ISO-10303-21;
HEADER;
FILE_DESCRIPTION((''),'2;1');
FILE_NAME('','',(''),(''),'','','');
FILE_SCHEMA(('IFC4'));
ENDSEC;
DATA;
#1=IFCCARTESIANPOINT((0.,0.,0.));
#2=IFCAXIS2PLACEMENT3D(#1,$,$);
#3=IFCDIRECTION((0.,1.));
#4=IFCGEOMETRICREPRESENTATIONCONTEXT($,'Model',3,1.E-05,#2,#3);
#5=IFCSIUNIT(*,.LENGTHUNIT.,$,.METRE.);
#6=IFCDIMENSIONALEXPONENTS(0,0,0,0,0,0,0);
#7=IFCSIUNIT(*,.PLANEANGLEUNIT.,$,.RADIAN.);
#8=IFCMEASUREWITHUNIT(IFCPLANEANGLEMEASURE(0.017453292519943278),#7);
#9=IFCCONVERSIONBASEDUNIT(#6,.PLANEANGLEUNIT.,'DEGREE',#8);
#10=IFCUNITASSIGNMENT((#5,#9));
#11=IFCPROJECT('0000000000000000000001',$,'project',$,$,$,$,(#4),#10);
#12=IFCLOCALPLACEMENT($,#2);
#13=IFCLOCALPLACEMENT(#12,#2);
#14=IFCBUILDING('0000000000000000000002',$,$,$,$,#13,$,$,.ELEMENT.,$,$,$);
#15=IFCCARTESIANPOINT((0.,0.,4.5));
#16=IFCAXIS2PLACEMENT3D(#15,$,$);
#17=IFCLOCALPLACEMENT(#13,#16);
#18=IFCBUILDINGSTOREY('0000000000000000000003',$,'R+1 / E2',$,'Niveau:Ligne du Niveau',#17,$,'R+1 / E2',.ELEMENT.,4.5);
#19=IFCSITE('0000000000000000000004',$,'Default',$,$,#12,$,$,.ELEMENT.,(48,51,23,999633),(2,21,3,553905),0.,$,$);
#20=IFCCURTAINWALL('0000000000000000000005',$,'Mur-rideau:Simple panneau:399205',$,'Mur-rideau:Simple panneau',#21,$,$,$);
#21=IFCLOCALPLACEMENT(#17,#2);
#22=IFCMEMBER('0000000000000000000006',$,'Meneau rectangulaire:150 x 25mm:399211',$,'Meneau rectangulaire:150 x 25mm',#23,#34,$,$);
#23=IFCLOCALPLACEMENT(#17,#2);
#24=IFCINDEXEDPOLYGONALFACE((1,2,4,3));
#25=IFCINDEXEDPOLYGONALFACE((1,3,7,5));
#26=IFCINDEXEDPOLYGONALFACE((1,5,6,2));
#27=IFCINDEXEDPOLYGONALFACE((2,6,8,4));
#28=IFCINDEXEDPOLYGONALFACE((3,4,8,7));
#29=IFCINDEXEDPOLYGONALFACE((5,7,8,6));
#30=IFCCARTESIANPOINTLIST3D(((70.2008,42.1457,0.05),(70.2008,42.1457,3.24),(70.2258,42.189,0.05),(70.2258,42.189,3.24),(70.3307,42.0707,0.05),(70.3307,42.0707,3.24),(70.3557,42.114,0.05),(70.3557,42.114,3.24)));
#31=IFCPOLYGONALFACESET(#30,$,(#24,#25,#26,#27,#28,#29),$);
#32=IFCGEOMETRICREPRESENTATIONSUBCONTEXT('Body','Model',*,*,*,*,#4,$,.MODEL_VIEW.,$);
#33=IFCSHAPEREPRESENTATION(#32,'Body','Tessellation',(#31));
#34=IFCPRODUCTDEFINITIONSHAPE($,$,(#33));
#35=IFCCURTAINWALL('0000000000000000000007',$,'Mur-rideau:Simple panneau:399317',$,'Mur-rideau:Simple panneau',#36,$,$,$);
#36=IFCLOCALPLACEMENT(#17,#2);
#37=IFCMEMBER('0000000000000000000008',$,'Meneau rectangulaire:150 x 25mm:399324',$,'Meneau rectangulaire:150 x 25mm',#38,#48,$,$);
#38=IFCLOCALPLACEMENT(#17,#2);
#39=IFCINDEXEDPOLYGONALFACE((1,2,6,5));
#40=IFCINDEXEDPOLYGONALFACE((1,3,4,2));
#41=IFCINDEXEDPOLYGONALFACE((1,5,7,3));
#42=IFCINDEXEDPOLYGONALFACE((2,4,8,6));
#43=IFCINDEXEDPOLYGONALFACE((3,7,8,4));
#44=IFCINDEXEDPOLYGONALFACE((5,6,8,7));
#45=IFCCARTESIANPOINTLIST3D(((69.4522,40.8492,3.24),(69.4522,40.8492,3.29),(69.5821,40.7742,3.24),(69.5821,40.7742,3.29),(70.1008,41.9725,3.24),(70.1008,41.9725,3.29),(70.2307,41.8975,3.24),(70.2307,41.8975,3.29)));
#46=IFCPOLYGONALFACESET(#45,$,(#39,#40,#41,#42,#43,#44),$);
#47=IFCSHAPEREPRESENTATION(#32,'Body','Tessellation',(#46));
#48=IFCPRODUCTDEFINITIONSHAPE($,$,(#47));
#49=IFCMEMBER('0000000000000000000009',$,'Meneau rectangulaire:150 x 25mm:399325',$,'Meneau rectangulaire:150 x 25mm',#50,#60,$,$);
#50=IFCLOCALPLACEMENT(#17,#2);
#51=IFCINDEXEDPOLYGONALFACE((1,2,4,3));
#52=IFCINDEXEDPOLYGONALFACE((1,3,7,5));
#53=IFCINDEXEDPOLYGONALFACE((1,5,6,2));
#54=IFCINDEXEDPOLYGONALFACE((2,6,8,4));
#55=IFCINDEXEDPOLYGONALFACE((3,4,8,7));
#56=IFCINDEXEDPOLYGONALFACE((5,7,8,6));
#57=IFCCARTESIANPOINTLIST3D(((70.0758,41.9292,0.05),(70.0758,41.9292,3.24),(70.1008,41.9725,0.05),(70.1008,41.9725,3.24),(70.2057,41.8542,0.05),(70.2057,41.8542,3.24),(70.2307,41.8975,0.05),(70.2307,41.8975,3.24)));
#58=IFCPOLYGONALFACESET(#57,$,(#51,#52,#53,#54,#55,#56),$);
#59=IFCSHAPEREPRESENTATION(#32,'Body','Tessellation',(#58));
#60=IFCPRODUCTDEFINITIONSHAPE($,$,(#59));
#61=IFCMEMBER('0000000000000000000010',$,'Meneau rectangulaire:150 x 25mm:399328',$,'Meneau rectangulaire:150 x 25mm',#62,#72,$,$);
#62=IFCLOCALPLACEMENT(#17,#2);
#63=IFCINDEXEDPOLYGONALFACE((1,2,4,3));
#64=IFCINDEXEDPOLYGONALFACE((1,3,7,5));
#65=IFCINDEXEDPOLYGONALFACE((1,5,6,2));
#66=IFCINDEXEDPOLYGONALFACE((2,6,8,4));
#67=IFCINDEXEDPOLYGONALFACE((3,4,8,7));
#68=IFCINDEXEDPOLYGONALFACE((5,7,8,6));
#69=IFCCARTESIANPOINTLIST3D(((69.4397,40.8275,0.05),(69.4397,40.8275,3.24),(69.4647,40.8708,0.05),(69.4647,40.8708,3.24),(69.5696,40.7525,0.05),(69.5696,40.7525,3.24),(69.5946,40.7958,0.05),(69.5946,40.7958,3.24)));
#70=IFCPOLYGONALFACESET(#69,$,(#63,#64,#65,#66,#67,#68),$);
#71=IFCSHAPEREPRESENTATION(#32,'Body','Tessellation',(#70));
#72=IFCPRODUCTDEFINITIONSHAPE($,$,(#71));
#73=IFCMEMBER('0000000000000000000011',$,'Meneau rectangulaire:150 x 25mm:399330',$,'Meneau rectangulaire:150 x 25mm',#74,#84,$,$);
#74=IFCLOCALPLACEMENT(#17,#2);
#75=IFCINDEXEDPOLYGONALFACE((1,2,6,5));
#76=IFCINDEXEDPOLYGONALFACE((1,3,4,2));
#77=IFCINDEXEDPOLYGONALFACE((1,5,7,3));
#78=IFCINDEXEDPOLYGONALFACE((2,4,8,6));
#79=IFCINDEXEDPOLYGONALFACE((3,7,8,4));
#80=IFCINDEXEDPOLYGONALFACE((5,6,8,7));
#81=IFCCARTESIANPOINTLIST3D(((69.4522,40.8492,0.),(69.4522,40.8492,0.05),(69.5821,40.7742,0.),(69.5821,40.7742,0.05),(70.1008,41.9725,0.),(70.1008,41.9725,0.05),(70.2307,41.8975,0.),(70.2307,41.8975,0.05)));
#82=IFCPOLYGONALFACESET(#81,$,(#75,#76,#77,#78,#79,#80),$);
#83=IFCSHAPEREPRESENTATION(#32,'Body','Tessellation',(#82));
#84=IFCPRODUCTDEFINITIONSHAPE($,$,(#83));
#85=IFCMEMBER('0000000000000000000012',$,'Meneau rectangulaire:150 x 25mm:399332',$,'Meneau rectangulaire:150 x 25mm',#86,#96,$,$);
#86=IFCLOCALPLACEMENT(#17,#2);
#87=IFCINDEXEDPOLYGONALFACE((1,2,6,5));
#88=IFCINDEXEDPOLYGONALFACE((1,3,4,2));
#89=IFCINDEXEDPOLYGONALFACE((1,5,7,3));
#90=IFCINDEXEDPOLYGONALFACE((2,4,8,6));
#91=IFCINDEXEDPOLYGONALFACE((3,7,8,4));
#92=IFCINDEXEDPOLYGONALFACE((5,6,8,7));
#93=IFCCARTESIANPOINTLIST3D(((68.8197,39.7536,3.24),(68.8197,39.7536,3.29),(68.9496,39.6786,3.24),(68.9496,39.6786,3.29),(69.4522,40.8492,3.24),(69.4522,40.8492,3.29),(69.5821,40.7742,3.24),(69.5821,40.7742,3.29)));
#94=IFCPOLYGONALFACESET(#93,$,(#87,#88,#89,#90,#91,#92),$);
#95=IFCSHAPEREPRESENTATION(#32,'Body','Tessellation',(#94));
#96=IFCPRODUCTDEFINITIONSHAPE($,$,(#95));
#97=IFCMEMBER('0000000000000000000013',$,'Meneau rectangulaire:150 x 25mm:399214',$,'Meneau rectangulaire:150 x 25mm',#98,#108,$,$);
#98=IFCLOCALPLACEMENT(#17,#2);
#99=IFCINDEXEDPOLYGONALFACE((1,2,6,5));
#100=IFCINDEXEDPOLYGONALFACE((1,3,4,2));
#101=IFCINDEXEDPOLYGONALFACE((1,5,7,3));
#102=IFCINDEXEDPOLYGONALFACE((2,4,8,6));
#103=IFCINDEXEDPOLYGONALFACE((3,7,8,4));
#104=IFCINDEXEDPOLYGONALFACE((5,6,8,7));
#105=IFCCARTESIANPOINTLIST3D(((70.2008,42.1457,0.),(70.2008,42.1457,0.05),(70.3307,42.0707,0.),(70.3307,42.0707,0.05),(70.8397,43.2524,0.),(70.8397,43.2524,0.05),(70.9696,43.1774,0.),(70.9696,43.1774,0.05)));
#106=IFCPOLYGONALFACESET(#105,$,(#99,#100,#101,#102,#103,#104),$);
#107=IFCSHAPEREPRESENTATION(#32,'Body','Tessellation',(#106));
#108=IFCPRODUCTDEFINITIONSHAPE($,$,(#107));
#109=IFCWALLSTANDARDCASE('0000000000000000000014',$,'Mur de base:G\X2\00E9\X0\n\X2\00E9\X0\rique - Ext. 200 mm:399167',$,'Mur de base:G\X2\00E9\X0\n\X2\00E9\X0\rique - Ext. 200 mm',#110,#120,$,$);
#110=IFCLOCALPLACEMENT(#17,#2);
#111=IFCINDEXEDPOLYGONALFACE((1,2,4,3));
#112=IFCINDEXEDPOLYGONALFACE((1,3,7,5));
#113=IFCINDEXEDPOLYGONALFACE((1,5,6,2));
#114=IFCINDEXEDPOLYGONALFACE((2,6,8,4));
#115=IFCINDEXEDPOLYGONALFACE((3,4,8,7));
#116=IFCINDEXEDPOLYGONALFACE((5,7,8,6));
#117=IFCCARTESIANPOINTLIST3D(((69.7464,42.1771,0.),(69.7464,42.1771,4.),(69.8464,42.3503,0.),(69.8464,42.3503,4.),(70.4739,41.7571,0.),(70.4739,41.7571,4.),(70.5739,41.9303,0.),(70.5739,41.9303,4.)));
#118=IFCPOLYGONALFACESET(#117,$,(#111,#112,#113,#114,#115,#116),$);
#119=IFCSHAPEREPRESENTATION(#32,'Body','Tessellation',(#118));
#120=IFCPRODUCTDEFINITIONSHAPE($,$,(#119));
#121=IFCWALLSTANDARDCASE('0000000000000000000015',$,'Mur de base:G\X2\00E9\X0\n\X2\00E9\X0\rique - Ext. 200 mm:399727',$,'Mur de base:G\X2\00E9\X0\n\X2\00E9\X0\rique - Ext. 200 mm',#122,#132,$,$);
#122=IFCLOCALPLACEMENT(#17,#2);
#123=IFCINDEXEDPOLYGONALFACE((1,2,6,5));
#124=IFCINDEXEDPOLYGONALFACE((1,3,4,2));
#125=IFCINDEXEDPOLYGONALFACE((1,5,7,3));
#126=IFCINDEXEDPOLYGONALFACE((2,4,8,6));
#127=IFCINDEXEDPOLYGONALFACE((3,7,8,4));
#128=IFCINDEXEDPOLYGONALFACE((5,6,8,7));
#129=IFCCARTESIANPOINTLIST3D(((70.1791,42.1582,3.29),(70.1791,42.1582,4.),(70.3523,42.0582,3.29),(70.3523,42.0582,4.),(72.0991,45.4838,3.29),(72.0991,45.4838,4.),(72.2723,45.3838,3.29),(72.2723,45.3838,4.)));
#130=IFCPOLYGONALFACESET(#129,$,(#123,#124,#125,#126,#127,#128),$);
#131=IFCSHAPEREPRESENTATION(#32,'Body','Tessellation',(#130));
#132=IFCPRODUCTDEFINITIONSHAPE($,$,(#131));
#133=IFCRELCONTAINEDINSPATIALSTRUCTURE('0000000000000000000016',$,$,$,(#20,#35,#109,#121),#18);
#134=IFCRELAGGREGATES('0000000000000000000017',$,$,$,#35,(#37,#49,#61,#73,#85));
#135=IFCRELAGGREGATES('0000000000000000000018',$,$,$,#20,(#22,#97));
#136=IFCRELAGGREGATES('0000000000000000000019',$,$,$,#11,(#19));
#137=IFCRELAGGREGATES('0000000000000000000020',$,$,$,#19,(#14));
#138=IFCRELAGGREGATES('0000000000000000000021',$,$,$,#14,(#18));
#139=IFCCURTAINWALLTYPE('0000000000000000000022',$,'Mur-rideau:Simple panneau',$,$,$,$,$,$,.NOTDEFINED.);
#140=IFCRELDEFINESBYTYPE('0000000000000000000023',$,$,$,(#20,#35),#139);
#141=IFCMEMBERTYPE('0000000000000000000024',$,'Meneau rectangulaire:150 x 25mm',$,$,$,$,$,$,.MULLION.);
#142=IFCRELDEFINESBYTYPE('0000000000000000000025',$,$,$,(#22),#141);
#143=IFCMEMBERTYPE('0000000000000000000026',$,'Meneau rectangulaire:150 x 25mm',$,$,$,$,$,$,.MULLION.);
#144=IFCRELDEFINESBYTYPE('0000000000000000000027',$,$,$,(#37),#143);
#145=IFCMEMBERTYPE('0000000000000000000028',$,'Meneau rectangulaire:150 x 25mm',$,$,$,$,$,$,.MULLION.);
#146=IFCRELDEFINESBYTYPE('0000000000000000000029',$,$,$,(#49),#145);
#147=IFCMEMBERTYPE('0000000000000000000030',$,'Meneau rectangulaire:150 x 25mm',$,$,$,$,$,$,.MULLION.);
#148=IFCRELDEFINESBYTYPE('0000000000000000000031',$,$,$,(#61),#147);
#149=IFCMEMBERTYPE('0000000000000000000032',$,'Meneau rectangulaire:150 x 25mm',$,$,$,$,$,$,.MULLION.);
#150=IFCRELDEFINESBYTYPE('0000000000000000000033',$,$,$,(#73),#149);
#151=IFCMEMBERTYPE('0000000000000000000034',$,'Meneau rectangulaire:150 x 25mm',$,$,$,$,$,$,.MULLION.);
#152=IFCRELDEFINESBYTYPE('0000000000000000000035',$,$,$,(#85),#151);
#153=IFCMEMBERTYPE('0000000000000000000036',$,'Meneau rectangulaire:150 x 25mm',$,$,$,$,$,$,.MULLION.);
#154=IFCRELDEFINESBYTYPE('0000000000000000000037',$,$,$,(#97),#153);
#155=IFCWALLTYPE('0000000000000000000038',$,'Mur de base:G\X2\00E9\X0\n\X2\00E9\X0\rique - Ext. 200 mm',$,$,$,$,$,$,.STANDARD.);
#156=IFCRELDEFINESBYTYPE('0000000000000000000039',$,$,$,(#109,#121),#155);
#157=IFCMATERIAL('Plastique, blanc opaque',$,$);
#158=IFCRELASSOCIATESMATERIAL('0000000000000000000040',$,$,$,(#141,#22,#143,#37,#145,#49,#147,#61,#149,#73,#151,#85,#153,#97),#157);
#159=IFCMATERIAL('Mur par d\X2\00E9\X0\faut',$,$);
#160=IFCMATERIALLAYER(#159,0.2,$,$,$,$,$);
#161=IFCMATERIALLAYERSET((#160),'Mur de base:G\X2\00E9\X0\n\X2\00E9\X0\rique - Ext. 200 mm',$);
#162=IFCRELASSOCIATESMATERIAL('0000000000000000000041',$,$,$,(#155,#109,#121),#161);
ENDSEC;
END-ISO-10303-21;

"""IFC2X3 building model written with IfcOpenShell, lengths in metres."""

from ifc_helpers import new_model, entity, si_unit, converted_unit, direction, frame, frame_2d, origin, origin_2d_with_axis, place, context, subcontext, project, spatial, rectangle, extrude, source, transform, mapped, material, layer, layer_set, layer_usage, type_object, type_shapes, element, aggregate, save


model = new_model("IFC2X3")

# Units and contexts
model_context = context("Model", 3, precision=1e-05, world=origin(), true_north=direction((0.0, 1.0)))
body_context = subcontext(model_context, "Body", "Model", "MODEL_VIEW")
ifc_project = project(units=[si_unit("LENGTHUNIT", "METRE"), converted_unit("PLANEANGLEUNIT", "DEGREE", entity("IfcPlaneAngleMeasure", 0.017453292519943278), si_unit("PLANEANGLEUNIT", "RADIAN"), dimensions=[0, 0, 0, 0, 0, 0, 0])], contexts=[model_context])

# Site, building, storey
site_placement = place(None, origin())
site = spatial("IfcSite", under=ifc_project, at=site_placement, Name="Default", CompositionType="ELEMENT", RefLatitude=(48, 51, 23, 999633), RefLongitude=(2, 21, 3, 553905), RefElevation=0.0)
building_placement = place(site_placement, origin())
building = spatial("IfcBuilding", under=site, at=building_placement, CompositionType="ELEMENT")
storey_placement = place(building_placement, frame((0.0, 0.0, 4.5)))
storey = spatial("IfcBuildingStorey", under=building, at=storey_placement, Name="R+1 / E2", ObjectType="Niveau:Ligne du Niveau", LongName="R+1 / E2", CompositionType="ELEMENT", Elevation=4.5)

# Curtain walls, members
curtain_wall_type = type_object("IfcCurtainWallType", Name="Mur-rideau:Simple panneau", PredefinedType="NOTDEFINED")
curtain_wall_1_placement = place(storey_placement, frame((0.0, 0.0, -4.5)))
curtain_wall_1 = element("IfcCurtainWall", 1, at=curtain_wall_1_placement, inside=storey, type_object=curtain_wall_type, Name="Mur-rideau:Simple panneau:399205", ObjectType="Mur-rideau:Simple panneau")
ifc_material_1 = material(Name="Plastique, blanc opaque")
member_type_1 = type_object("IfcMemberType", Name="Meneau rectangulaire:150 x 25mm", PredefinedType="MULLION", material=ifc_material_1)
shared_shape_1 = source(origin(), body_context, "Body", "SweptSolid", [
    extrude(rectangle(XDim=0.05, YDim=0.15, at=origin_2d_with_axis()), frame((-0.025, 0.0, -3.19), z_axis=(0.0, 0.0, 1.0), x_axis=(-1.0, 0.0, 0.0)), (0.0, 0.0, 1.0), 3.19),
])
type_shapes(member_type_1, [shared_shape_1])
member_1_placement = place(curtain_wall_1_placement, frame((70.2657, 42.1082, 7.74), z_axis=(0.0, 0.0, 1.0), x_axis=(-0.5, -0.866025, 0.0)))
member_1 = element("IfcMember", 2, at=member_1_placement, type_object=member_type_1, material=ifc_material_1, Name="Meneau rectangulaire:150 x 25mm:399211", ObjectType="Meneau rectangulaire:150 x 25mm", context=body_context, shape_type="MappedRepresentation", body=[
    mapped(shared_shape_1, transform((0.0, 0.0, 0.0), scale=1.0)),
])
curtain_wall_2_placement = place(storey_placement, frame((0.0, 0.0, -4.5)))
curtain_wall_2 = element("IfcCurtainWall", 3, at=curtain_wall_2_placement, inside=storey, type_object=curtain_wall_type, Name="Mur-rideau:Simple panneau:399317", ObjectType="Mur-rideau:Simple panneau")
member_type_2 = type_object("IfcMemberType", Name="Meneau rectangulaire:150 x 25mm", PredefinedType="MULLION", material=ifc_material_1)
shared_shape_2 = source(origin(), body_context, "Body", "SweptSolid", [
    extrude(rectangle(XDim=0.05, YDim=0.15, at=origin_2d_with_axis()), frame((-0.025, 0.0, -1.2971), z_axis=(0.0, 0.0, 1.0), x_axis=(-1.0, 0.0, 0.0)), (0.0, 0.0, 1.0), 1.2971),
])
type_shapes(member_type_2, [shared_shape_2])
member_2_placement = place(curtain_wall_2_placement, frame((70.1657, 41.935, 7.79), z_axis=(0.5, 0.866025, 0.0), x_axis=(0.0, 0.0, 1.0)))
member_2 = element("IfcMember", 4, at=member_2_placement, type_object=member_type_2, material=ifc_material_1, Name="Meneau rectangulaire:150 x 25mm:399324", ObjectType="Meneau rectangulaire:150 x 25mm", context=body_context, shape_type="MappedRepresentation", body=[
    mapped(shared_shape_2, transform((0.0, 0.0, 0.0), scale=1.0)),
])

# Members
member_type_3 = type_object("IfcMemberType", Name="Meneau rectangulaire:150 x 25mm", PredefinedType="MULLION", material=ifc_material_1)
shared_shape_3 = source(origin(), body_context, "Body", "SweptSolid", [
    extrude(rectangle(XDim=0.05, YDim=0.15, at=origin_2d_with_axis()), frame((-0.025, 0.0, -3.19), z_axis=(0.0, 0.0, 1.0), x_axis=(-1.0, 0.0, 0.0)), (0.0, 0.0, 1.0), 3.19),
])
type_shapes(member_type_3, [shared_shape_3])
member_3_placement = place(curtain_wall_2_placement, frame((70.1657, 41.935, 4.55), z_axis=(0.0, 0.0, -1.0), x_axis=(0.5, 0.866025, 0.0)))
member_3 = element("IfcMember", 5, at=member_3_placement, type_object=member_type_3, material=ifc_material_1, Name="Meneau rectangulaire:150 x 25mm:399325", ObjectType="Meneau rectangulaire:150 x 25mm", context=body_context, shape_type="MappedRepresentation", body=[
    mapped(shared_shape_3, transform((0.0, 0.0, 0.0), scale=1.0)),
])
member_type_4 = type_object("IfcMemberType", Name="Meneau rectangulaire:150 x 25mm", PredefinedType="MULLION", material=ifc_material_1)
shared_shape_4 = source(origin(), body_context, "Body", "SweptSolid", [
    extrude(rectangle(XDim=0.05, YDim=0.15, at=origin_2d_with_axis()), frame((0.0, 0.0, -3.19), z_axis=(0.0, 0.0, 1.0), x_axis=(-1.0, 0.0, 0.0)), (0.0, 0.0, 1.0), 3.19),
])
type_shapes(member_type_4, [shared_shape_4])
member_4_placement = place(curtain_wall_2_placement, frame((69.5172, 40.8117, 4.55), z_axis=(0.0, 0.0, -1.0), x_axis=(0.5, 0.866025, 0.0)))
member_4 = element("IfcMember", 6, at=member_4_placement, type_object=member_type_4, material=ifc_material_1, Name="Meneau rectangulaire:150 x 25mm:399328", ObjectType="Meneau rectangulaire:150 x 25mm", context=body_context, shape_type="MappedRepresentation", body=[
    mapped(shared_shape_4, transform((0.0, 0.0, 0.0), scale=1.0)),
])
member_type_5 = type_object("IfcMemberType", Name="Meneau rectangulaire:150 x 25mm", PredefinedType="MULLION", material=ifc_material_1)
shared_shape_5 = source(origin(), body_context, "Body", "SweptSolid", [
    extrude(rectangle(XDim=0.05, YDim=0.15, at=origin_2d_with_axis()), frame((-0.025, 0.0, -1.2971), z_axis=(0.0, 0.0, 1.0), x_axis=(-1.0, 0.0, 0.0)), (0.0, 0.0, 1.0), 1.2971),
])
type_shapes(member_type_5, [shared_shape_5])
member_5_placement = place(curtain_wall_2_placement, frame((69.5172, 40.8117, 4.5), z_axis=(-0.5, -0.866025, 0.0), x_axis=(0.0, 0.0, -1.0)))
member_5 = element("IfcMember", 7, at=member_5_placement, type_object=member_type_5, material=ifc_material_1, Name="Meneau rectangulaire:150 x 25mm:399330", ObjectType="Meneau rectangulaire:150 x 25mm", context=body_context, shape_type="MappedRepresentation", body=[
    mapped(shared_shape_5, transform((0.0, 0.0, 0.0), scale=1.0)),
])
member_type_6 = type_object("IfcMemberType", Name="Meneau rectangulaire:150 x 25mm", PredefinedType="MULLION", material=ifc_material_1)
shared_shape_6 = source(origin(), body_context, "Body", "SweptSolid", [
    extrude(rectangle(XDim=0.05, YDim=0.15, at=origin_2d_with_axis()), frame((-0.025, 0.0, -1.265), z_axis=(0.0, 0.0, 1.0), x_axis=(-1.0, 0.0, 0.0)), (0.0, 0.0, 1.0), 1.265),
])
type_shapes(member_type_6, [shared_shape_6])
member_6_placement = place(curtain_wall_2_placement, frame((69.5172, 40.8117, 7.79), z_axis=(0.5, 0.866025, 0.0), x_axis=(0.0, 0.0, 1.0)))
member_6 = element("IfcMember", 8, at=member_6_placement, type_object=member_type_6, material=ifc_material_1, Name="Meneau rectangulaire:150 x 25mm:399332", ObjectType="Meneau rectangulaire:150 x 25mm", context=body_context, shape_type="MappedRepresentation", body=[
    mapped(shared_shape_6, transform((0.0, 0.0, 0.0), scale=1.0)),
])
member_type_7 = type_object("IfcMemberType", Name="Meneau rectangulaire:150 x 25mm", PredefinedType="MULLION", material=ifc_material_1)
shared_shape_7 = source(origin(), body_context, "Body", "SweptSolid", [
    extrude(rectangle(XDim=0.05, YDim=0.15, at=origin_2d_with_axis()), frame((-0.025, 0.0, -1.2779), z_axis=(0.0, 0.0, 1.0), x_axis=(-1.0, 0.0, 0.0)), (0.0, 0.0, 1.0), 1.2779),
])
type_shapes(member_type_7, [shared_shape_7])
member_7_placement = place(curtain_wall_1_placement, frame((70.2657, 42.1082, 4.5), z_axis=(-0.5, -0.866025, 0.0), x_axis=(0.0, 0.0, -1.0)))
member_7 = element("IfcMember", 9, at=member_7_placement, type_object=member_type_7, material=ifc_material_1, Name="Meneau rectangulaire:150 x 25mm:399214", ObjectType="Meneau rectangulaire:150 x 25mm", context=body_context, shape_type="MappedRepresentation", body=[
    mapped(shared_shape_7, transform((0.0, 0.0, 0.0), scale=1.0)),
])

aggregate(curtain_wall_2, [member_2, member_3, member_4, member_5, member_6])
aggregate(curtain_wall_1, [member_1, member_7])

# Wall
ifc_material_2 = material(Name="Mur par défaut")
ifc_layer_1 = layer(ifc_material_2, 0.2)
ifc_layer_set_1 = layer_set([ifc_layer_1], Name="Mur de base:Générique - Ext. 200 mm")
ifc_layer_usage_1 = layer_usage(ifc_layer_set_1, "AXIS2", "NEGATIVE", 0.1)
wall_type = type_object("IfcWallType", Name="Mur de base:Générique - Ext. 200 mm", PredefinedType="STANDARD", material=ifc_layer_set_1)
wall_1_placement = place(storey_placement, frame((69.7964, 42.2637, 0.0), z_axis=(0.0, 0.0, 1.0), x_axis=(0.866025, -0.5, 0.0)))
element("IfcWallStandardCase", 10, at=wall_1_placement, inside=storey, type_object=wall_type, material=ifc_layer_usage_1, Name="Mur de base:Générique - Ext. 200 mm:399167", ObjectType="Mur de base:Générique - Ext. 200 mm", context=body_context, shape_type="SweptSolid", body=[
    extrude(rectangle(XDim=0.84, YDim=0.2, at=frame_2d((0.42, 0.0), x_axis=(-1.0, 0.0))), origin(), (0.0, 0.0, 1.0), 4.0),
])

# Wall, opening
ifc_layer_usage_2 = layer_usage(ifc_layer_set_1, "AXIS2", "NEGATIVE", 0.1)
wall_2_placement = place(storey_placement, frame((70.2657, 42.1082, 3.29), z_axis=(0.0, 0.0, 1.0), x_axis=(0.5, 0.866025, 0.0)))
wall_2 = element("IfcWallStandardCase", 11, at=wall_2_placement, inside=storey, type_object=wall_type, material=ifc_layer_usage_2, Name="Mur de base:Générique - Ext. 200 mm:399727", ObjectType="Mur de base:Générique - Ext. 200 mm", context=body_context, shape_type="SweptSolid", body=[
    extrude(rectangle(XDim=3.84, YDim=0.2, at=frame_2d((1.92, 0.0), x_axis=(1.0, 0.0))), origin(), (0.0, 0.0, 1.0), 0.71),
])
opening_placement = place(wall_2_placement, origin())
element("IfcOpeningElement", 12, at=opening_placement, cuts=wall_2, ObjectType="Opening", context=body_context, shape_type="SweptSolid", body=[
    extrude(rectangle(XDim=3.29, YDim=3.84, at=frame_2d((0.0, 0.0), x_axis=(1.0, 0.0))), frame((1.92, -0.2524, -1.645), z_axis=(0.0, 1.0, 0.0), x_axis=(0.0, 0.0, 1.0)), (0.0, 0.0, 1.0), 0.5048),
])

save(model, "model.ifc")
